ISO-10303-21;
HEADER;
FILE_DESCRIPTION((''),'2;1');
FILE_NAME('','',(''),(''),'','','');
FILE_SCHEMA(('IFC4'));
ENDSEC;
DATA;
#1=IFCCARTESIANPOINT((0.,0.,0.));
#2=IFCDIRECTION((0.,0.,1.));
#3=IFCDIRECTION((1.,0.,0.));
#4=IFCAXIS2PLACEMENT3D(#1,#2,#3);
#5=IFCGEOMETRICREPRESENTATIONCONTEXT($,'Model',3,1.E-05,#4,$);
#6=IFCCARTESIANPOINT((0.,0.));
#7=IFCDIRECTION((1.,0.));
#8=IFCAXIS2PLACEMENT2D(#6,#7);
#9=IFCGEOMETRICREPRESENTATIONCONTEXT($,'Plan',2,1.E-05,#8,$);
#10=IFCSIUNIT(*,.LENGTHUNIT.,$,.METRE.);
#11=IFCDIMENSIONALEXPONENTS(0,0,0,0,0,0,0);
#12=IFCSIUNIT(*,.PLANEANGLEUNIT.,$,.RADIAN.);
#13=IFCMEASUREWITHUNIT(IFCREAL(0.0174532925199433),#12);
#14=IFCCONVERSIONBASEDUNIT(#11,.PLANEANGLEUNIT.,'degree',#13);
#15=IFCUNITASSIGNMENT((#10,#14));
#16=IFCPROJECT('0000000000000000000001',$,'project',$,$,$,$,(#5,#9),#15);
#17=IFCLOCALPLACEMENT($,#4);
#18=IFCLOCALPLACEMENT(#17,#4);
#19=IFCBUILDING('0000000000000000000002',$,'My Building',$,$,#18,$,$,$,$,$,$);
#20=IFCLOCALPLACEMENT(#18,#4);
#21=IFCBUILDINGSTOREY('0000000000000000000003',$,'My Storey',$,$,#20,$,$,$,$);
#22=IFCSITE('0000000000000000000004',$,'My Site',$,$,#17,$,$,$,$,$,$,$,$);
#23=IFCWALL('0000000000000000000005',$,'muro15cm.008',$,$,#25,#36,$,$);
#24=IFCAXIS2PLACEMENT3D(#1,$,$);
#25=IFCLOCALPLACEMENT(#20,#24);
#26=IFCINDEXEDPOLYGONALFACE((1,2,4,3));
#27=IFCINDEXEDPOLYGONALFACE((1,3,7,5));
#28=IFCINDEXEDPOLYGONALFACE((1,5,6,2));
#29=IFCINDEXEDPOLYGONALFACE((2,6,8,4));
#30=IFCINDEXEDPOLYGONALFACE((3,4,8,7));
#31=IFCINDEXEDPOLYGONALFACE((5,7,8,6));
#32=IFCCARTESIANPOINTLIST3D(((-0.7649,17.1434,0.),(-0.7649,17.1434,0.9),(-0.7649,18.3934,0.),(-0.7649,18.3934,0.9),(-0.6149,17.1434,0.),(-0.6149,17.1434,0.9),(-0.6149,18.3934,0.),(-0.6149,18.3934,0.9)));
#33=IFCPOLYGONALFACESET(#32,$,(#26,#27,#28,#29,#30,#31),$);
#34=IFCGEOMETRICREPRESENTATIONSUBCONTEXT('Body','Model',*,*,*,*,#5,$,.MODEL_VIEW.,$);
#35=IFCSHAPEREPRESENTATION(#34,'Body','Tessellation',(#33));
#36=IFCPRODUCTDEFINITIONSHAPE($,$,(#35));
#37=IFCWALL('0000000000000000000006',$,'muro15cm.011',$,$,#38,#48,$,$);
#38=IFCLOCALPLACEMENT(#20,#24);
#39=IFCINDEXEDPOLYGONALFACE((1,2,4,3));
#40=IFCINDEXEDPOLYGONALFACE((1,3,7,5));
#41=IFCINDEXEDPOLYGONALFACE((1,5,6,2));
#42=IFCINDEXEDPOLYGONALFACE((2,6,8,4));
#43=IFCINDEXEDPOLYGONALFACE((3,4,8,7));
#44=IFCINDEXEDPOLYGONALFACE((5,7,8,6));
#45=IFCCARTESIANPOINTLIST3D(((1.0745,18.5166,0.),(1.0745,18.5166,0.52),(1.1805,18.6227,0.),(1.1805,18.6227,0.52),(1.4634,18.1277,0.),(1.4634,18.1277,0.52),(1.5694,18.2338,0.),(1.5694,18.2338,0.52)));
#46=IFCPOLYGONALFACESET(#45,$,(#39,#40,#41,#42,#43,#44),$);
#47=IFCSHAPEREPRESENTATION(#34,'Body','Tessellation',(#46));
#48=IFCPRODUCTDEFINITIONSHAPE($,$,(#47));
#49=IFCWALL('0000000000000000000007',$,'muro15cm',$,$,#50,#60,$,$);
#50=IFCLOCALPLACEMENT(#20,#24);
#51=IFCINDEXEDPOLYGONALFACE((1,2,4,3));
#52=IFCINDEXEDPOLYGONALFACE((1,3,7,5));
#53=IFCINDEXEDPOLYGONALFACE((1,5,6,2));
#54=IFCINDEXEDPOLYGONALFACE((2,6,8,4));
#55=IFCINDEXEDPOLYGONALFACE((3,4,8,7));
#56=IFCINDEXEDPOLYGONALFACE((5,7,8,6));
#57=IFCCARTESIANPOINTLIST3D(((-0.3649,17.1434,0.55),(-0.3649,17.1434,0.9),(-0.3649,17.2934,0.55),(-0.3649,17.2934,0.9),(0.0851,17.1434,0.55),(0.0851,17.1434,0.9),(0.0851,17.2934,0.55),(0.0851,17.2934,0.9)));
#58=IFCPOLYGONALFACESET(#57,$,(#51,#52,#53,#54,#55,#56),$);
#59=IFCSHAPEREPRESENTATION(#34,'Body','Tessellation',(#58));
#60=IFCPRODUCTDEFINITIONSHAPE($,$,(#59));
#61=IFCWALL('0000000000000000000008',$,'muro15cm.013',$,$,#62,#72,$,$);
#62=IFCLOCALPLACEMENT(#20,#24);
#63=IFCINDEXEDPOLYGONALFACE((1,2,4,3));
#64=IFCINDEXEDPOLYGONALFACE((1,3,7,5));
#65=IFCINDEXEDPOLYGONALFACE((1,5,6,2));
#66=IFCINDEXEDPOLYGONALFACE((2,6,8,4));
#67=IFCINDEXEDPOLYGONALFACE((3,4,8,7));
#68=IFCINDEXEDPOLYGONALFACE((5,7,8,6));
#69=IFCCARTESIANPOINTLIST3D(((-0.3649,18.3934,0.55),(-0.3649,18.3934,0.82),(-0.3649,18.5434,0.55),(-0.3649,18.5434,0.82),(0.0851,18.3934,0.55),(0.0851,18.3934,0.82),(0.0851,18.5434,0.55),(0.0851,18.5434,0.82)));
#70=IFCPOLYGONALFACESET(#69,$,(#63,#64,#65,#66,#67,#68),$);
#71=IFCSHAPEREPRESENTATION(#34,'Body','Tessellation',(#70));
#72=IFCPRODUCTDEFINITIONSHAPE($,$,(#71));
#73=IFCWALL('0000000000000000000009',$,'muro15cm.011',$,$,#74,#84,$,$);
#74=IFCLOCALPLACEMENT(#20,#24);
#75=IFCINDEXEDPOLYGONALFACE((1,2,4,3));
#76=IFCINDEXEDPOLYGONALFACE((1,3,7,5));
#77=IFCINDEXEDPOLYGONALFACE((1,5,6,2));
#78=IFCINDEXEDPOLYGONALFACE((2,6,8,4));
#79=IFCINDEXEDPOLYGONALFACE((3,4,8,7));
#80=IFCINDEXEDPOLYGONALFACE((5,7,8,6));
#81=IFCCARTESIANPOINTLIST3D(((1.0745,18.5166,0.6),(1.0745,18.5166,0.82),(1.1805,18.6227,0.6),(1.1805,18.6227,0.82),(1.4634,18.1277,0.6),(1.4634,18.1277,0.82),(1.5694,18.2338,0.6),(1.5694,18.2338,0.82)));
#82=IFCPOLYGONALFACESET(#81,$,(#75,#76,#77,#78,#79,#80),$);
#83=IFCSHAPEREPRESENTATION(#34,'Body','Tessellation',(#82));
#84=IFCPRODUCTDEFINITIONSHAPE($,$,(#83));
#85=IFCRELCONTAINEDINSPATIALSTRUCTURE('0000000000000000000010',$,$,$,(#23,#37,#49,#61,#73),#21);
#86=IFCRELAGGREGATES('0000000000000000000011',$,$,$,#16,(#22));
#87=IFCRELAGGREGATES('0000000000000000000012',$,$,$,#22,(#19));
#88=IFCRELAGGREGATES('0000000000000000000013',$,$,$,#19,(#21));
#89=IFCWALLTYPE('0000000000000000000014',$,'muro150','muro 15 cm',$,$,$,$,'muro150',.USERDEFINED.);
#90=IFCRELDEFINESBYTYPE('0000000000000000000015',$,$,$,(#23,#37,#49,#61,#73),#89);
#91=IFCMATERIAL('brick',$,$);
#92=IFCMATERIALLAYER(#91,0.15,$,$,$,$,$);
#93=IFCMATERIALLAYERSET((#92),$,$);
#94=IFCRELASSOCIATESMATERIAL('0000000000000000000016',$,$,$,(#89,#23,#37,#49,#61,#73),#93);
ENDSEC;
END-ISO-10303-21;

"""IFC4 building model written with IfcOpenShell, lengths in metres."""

from ifc_helpers import new_model, entity, si_unit, converted_unit, frame, origin_with_axes, origin_2d_with_axis, place, context, subcontext, project, spatial, indexed_curve, outline, extrude, material, layer, layer_set, layer_usage, type_object, element, save


model = new_model("IFC4")

# Units and contexts
model_context = context("Model", 3, precision=1e-05, world=origin_with_axes())
plan_context = context("Plan", 2, precision=1e-05, world=origin_2d_with_axis())
body_context = subcontext(model_context, "Body", "Model", "MODEL_VIEW")
ifc_project = project(units=[si_unit("LENGTHUNIT", "METRE"), converted_unit("PLANEANGLEUNIT", "degree", entity("IfcReal", 0.0174532925199433), si_unit("PLANEANGLEUNIT", "RADIAN"), dimensions=[0, 0, 0, 0, 0, 0, 0])], contexts=[model_context, plan_context])

# Site, building, storey
site_placement = place(None, origin_with_axes())
site = spatial("IfcSite", under=ifc_project, at=site_placement, Name="My Site")
building_placement = place(site_placement, origin_with_axes())
building = spatial("IfcBuilding", under=site, at=building_placement, Name="My Building")
storey_placement = place(building_placement, origin_with_axes())
storey = spatial("IfcBuildingStorey", under=building, at=storey_placement, Name="My Storey")

# Walls
ifc_material_1 = material(Name="brick")
ifc_layer_1 = layer(ifc_material_1, 0.15)
ifc_layer_set_1 = layer_set([ifc_layer_1])
wall_type_1 = type_object("IfcWallType", Name="muro150", Description="muro 15 cm", ElementType="muro150", PredefinedType="USERDEFINED", material=ifc_layer_set_1)
ifc_layer_usage_1 = layer_usage(ifc_layer_set_1, "AXIS2", "POSITIVE", 0.0)
wall_1_placement = place(storey_placement, frame((-0.7649, 18.3934, 0.0), z_axis=(0.0, 0.0, 1.0), x_axis=(0.0, -1.0, 0.0)))
element("IfcWall", 1, at=wall_1_placement, inside=storey, type_object=wall_type_1, material=ifc_layer_usage_1, Name="muro15cm.008", context=body_context, shape_type="SweptSolid", body=[
    extrude(outline(indexed_curve([(0.0, 0.0), (0.0, 0.15), (1.25, 0.15), (1.25, 0.0), (0.0, 0.0)], self_intersect=False)), origin_with_axes(), (0.0, 0.0, 1.0), 0.9),
])
ifc_layer_usage_2 = layer_usage(ifc_layer_set_1, "AXIS2", "POSITIVE", 0.0)
wall_2_placement = place(storey_placement, frame((1.0745, 18.5166, 0.0), z_axis=(0.0, 0.0, 1.0), x_axis=(0.707107, -0.707107, 0.0)))
element("IfcWall", 2, at=wall_2_placement, inside=storey, type_object=wall_type_1, material=ifc_layer_usage_2, Name="muro15cm.011", context=body_context, shape_type="SweptSolid", body=[
    extrude(outline(indexed_curve([(0.0, 0.0), (0.0, 0.15), (0.55, 0.15), (0.55, 0.0), (0.0, 0.0)], self_intersect=False)), origin_with_axes(), (0.0, 0.0, 1.0), 0.52),
])
ifc_layer_usage_3 = layer_usage(ifc_layer_set_1, "AXIS2", "POSITIVE", 0.0)
wall_3_placement = place(storey_placement, frame((-0.3649, 17.1434, 0.55), z_axis=(0.0, 0.0, 1.0), x_axis=(1.0, 0.0, 0.0)))
element("IfcWall", 3, at=wall_3_placement, inside=storey, type_object=wall_type_1, material=ifc_layer_usage_3, Name="muro15cm", context=body_context, shape_type="SweptSolid", body=[
    extrude(outline(indexed_curve([(0.0, 0.0), (0.0, 0.15), (0.45, 0.15), (0.45, 0.0), (0.0, 0.0)], self_intersect=False)), origin_with_axes(), (0.0, 0.0, 1.0), 0.35),
])
ifc_layer_usage_4 = layer_usage(ifc_layer_set_1, "AXIS2", "POSITIVE", 0.0)
wall_4_placement = place(storey_placement, frame((-0.3649, 18.3934, 0.55), z_axis=(0.0, 0.0, 1.0), x_axis=(1.0, 0.0, 0.0)))
element("IfcWall", 4, at=wall_4_placement, inside=storey, type_object=wall_type_1, material=ifc_layer_usage_4, Name="muro15cm.013", context=body_context, shape_type="SweptSolid", body=[
    extrude(outline(indexed_curve([(0.0, 0.0), (0.0, 0.15), (0.45, 0.15), (0.45, 0.0), (0.0, 0.0)], self_intersect=False)), origin_with_axes(), (0.0, 0.0, 1.0), 0.27),
])
ifc_layer_usage_5 = layer_usage(ifc_layer_set_1, "AXIS2", "POSITIVE", 0.0)
wall_5_placement = place(storey_placement, frame((1.0745, 18.5166, 0.6), z_axis=(0.0, 0.0, 1.0), x_axis=(0.707107, -0.707107, 0.0)))
element("IfcWall", 5, at=wall_5_placement, inside=storey, type_object=wall_type_1, material=ifc_layer_usage_5, Name="muro15cm.011", context=body_context, shape_type="SweptSolid", body=[
    extrude(outline(indexed_curve([(0.0, 0.0), (0.0, 0.15), (0.55, 0.15), (0.55, 0.0), (0.0, 0.0)], self_intersect=False)), origin_with_axes(), (0.0, 0.0, 1.0), 0.22),
])

save(model, "model.ifc")
